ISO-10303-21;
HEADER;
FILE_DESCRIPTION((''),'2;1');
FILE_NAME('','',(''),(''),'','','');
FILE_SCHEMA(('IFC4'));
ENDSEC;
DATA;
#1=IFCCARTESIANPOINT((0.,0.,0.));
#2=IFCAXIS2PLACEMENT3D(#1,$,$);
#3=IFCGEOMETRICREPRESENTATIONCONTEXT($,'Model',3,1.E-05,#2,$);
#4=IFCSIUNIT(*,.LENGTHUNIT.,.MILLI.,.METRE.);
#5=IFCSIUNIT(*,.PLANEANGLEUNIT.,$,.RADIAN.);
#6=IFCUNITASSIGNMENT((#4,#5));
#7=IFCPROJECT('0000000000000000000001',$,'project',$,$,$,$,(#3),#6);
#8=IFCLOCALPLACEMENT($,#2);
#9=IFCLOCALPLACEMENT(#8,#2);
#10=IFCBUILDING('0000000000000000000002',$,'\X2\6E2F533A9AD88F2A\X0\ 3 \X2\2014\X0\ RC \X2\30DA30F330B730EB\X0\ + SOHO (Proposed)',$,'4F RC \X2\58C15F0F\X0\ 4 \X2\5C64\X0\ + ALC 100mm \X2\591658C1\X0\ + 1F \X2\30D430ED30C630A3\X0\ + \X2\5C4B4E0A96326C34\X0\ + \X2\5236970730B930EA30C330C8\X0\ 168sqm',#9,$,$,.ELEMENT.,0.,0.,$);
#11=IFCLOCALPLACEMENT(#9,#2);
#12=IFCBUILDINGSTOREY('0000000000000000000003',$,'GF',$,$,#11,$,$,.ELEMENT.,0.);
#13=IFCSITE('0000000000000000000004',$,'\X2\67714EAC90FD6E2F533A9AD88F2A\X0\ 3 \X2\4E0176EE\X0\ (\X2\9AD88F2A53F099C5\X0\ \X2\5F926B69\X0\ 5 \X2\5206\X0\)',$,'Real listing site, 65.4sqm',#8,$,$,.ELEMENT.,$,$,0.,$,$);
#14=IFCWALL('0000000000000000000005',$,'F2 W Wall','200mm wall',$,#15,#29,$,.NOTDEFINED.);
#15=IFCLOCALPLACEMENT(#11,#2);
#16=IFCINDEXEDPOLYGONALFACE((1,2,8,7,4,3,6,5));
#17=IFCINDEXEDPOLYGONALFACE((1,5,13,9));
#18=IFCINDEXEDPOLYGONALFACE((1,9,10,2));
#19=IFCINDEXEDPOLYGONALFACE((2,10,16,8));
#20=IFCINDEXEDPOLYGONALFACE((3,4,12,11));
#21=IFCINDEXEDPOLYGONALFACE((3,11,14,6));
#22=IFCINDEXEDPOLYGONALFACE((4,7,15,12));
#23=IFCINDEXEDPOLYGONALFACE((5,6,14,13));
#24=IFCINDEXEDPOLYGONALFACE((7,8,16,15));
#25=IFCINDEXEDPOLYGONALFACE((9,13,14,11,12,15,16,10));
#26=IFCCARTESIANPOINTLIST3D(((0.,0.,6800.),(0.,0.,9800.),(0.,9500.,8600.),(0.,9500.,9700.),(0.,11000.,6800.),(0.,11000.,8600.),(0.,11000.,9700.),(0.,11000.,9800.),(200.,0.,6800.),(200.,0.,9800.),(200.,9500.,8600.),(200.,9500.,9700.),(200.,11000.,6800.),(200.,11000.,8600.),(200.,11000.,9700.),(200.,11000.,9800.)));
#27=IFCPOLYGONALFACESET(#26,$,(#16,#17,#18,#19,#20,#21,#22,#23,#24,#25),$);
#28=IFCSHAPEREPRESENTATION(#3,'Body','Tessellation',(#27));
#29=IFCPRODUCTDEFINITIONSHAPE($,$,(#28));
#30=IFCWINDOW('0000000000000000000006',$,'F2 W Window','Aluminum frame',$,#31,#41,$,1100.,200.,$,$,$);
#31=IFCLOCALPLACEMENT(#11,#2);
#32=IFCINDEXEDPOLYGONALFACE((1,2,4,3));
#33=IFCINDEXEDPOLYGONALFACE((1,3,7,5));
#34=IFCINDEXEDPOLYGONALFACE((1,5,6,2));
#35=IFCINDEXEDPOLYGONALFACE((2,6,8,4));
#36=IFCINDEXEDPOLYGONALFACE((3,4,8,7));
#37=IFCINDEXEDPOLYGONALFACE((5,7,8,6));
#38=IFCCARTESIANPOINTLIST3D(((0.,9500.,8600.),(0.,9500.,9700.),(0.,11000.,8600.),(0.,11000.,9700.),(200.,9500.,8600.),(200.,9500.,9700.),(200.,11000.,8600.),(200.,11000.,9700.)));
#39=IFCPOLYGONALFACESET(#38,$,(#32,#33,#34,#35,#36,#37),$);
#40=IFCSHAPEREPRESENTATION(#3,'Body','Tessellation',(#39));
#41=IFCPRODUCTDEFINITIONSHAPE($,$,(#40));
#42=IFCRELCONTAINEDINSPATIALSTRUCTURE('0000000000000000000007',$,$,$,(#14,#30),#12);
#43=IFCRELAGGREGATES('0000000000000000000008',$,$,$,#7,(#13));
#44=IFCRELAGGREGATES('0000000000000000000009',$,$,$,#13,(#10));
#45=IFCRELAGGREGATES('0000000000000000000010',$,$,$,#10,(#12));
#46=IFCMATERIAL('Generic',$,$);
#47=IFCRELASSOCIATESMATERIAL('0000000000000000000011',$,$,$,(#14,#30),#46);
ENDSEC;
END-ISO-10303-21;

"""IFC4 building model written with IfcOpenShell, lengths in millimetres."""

from ifc_helpers import new_model, si_unit, frame, frame_2d, origin, place, context, project, spatial, rectangle, extrude, material, element, fill, save


model = new_model("IFC4")

# Units and contexts
model_context = context("Model", 3, precision=1e-05, world=origin())
ifc_project = project(units=[si_unit("LENGTHUNIT", "METRE", prefix="MILLI"), si_unit("PLANEANGLEUNIT", "RADIAN")], contexts=[model_context])

# Site, building, storey
site_placement = place(None, origin())
site = spatial("IfcSite", under=ifc_project, at=site_placement, Name="東京都港区高輪 3 丁目 (高輪台駅 徒歩 5 分)", ObjectType="Real listing site, 65.4sqm", CompositionType="ELEMENT", RefElevation=0.0)
building_placement = place(site_placement, origin())
building = spatial("IfcBuilding", under=site, at=building_placement, Name="港区高輪 3 — RC ペンシル + SOHO (Proposed)", ObjectType="4F RC 壁式 4 層 + ALC 100mm 外壁 + 1F ピロティ + 屋上防水 + 制震スリット 168sqm", CompositionType="ELEMENT", ElevationOfRefHeight=0.0, ElevationOfTerrain=0.0)
storey_placement = place(building_placement, origin())
storey = spatial("IfcBuildingStorey", under=building, at=storey_placement, Name="GF", CompositionType="ELEMENT", Elevation=0.0)

# Shared definitions
ifc_material_1 = material(Name="Generic")

# Wall, opening, window
wall_1_placement = place(storey_placement, frame((0.0, 0.0, 3400.0)))
wall_1 = element("IfcWall", 1, at=wall_1_placement, inside=storey, material=ifc_material_1, Name="F2 W Wall", Description="200mm wall", PredefinedType="NOTDEFINED", context=model_context, shape_type="SweptSolid", body=[
    extrude(rectangle(XDim=200.0, YDim=11000.0, at=frame_2d((100.0, 5500.0))), frame((0.0, 0.0, 3400.0)), (0.0, 0.0, 1.0), 3000.0),
])
opening_1_placement = place(storey_placement, frame((0.0, 4750.0, 4300.0)))
opening_1 = element("IfcOpeningElement", 2, at=opening_1_placement, cuts=wall_1, PredefinedType="NOTDEFINED", context=model_context, shape_type="SweptSolid", body=[
    extrude(rectangle(XDim=200.0, YDim=1500.0, at=frame_2d((100.0, 750.0))), frame((0.0, 4750.0, 4300.0)), (0.0, 0.0, 1.0), 1100.0),
])
window_1_placement = place(storey_placement, frame((0.0, 4750.0, 4300.0)))
window_1 = element("IfcWindow", 3, at=window_1_placement, inside=storey, material=ifc_material_1, Name="F2 W Window", Description="Aluminum frame", OverallHeight=1100.0, OverallWidth=200.0, context=model_context, shape_type="SweptSolid", body=[
    extrude(rectangle(XDim=200.0, YDim=1500.0, at=frame_2d((100.0, 750.0))), frame((0.0, 4750.0, 4300.0)), (0.0, 0.0, 1.0), 1100.0),
])
fill(opening_1, window_1)

save(model, "model.ifc")
